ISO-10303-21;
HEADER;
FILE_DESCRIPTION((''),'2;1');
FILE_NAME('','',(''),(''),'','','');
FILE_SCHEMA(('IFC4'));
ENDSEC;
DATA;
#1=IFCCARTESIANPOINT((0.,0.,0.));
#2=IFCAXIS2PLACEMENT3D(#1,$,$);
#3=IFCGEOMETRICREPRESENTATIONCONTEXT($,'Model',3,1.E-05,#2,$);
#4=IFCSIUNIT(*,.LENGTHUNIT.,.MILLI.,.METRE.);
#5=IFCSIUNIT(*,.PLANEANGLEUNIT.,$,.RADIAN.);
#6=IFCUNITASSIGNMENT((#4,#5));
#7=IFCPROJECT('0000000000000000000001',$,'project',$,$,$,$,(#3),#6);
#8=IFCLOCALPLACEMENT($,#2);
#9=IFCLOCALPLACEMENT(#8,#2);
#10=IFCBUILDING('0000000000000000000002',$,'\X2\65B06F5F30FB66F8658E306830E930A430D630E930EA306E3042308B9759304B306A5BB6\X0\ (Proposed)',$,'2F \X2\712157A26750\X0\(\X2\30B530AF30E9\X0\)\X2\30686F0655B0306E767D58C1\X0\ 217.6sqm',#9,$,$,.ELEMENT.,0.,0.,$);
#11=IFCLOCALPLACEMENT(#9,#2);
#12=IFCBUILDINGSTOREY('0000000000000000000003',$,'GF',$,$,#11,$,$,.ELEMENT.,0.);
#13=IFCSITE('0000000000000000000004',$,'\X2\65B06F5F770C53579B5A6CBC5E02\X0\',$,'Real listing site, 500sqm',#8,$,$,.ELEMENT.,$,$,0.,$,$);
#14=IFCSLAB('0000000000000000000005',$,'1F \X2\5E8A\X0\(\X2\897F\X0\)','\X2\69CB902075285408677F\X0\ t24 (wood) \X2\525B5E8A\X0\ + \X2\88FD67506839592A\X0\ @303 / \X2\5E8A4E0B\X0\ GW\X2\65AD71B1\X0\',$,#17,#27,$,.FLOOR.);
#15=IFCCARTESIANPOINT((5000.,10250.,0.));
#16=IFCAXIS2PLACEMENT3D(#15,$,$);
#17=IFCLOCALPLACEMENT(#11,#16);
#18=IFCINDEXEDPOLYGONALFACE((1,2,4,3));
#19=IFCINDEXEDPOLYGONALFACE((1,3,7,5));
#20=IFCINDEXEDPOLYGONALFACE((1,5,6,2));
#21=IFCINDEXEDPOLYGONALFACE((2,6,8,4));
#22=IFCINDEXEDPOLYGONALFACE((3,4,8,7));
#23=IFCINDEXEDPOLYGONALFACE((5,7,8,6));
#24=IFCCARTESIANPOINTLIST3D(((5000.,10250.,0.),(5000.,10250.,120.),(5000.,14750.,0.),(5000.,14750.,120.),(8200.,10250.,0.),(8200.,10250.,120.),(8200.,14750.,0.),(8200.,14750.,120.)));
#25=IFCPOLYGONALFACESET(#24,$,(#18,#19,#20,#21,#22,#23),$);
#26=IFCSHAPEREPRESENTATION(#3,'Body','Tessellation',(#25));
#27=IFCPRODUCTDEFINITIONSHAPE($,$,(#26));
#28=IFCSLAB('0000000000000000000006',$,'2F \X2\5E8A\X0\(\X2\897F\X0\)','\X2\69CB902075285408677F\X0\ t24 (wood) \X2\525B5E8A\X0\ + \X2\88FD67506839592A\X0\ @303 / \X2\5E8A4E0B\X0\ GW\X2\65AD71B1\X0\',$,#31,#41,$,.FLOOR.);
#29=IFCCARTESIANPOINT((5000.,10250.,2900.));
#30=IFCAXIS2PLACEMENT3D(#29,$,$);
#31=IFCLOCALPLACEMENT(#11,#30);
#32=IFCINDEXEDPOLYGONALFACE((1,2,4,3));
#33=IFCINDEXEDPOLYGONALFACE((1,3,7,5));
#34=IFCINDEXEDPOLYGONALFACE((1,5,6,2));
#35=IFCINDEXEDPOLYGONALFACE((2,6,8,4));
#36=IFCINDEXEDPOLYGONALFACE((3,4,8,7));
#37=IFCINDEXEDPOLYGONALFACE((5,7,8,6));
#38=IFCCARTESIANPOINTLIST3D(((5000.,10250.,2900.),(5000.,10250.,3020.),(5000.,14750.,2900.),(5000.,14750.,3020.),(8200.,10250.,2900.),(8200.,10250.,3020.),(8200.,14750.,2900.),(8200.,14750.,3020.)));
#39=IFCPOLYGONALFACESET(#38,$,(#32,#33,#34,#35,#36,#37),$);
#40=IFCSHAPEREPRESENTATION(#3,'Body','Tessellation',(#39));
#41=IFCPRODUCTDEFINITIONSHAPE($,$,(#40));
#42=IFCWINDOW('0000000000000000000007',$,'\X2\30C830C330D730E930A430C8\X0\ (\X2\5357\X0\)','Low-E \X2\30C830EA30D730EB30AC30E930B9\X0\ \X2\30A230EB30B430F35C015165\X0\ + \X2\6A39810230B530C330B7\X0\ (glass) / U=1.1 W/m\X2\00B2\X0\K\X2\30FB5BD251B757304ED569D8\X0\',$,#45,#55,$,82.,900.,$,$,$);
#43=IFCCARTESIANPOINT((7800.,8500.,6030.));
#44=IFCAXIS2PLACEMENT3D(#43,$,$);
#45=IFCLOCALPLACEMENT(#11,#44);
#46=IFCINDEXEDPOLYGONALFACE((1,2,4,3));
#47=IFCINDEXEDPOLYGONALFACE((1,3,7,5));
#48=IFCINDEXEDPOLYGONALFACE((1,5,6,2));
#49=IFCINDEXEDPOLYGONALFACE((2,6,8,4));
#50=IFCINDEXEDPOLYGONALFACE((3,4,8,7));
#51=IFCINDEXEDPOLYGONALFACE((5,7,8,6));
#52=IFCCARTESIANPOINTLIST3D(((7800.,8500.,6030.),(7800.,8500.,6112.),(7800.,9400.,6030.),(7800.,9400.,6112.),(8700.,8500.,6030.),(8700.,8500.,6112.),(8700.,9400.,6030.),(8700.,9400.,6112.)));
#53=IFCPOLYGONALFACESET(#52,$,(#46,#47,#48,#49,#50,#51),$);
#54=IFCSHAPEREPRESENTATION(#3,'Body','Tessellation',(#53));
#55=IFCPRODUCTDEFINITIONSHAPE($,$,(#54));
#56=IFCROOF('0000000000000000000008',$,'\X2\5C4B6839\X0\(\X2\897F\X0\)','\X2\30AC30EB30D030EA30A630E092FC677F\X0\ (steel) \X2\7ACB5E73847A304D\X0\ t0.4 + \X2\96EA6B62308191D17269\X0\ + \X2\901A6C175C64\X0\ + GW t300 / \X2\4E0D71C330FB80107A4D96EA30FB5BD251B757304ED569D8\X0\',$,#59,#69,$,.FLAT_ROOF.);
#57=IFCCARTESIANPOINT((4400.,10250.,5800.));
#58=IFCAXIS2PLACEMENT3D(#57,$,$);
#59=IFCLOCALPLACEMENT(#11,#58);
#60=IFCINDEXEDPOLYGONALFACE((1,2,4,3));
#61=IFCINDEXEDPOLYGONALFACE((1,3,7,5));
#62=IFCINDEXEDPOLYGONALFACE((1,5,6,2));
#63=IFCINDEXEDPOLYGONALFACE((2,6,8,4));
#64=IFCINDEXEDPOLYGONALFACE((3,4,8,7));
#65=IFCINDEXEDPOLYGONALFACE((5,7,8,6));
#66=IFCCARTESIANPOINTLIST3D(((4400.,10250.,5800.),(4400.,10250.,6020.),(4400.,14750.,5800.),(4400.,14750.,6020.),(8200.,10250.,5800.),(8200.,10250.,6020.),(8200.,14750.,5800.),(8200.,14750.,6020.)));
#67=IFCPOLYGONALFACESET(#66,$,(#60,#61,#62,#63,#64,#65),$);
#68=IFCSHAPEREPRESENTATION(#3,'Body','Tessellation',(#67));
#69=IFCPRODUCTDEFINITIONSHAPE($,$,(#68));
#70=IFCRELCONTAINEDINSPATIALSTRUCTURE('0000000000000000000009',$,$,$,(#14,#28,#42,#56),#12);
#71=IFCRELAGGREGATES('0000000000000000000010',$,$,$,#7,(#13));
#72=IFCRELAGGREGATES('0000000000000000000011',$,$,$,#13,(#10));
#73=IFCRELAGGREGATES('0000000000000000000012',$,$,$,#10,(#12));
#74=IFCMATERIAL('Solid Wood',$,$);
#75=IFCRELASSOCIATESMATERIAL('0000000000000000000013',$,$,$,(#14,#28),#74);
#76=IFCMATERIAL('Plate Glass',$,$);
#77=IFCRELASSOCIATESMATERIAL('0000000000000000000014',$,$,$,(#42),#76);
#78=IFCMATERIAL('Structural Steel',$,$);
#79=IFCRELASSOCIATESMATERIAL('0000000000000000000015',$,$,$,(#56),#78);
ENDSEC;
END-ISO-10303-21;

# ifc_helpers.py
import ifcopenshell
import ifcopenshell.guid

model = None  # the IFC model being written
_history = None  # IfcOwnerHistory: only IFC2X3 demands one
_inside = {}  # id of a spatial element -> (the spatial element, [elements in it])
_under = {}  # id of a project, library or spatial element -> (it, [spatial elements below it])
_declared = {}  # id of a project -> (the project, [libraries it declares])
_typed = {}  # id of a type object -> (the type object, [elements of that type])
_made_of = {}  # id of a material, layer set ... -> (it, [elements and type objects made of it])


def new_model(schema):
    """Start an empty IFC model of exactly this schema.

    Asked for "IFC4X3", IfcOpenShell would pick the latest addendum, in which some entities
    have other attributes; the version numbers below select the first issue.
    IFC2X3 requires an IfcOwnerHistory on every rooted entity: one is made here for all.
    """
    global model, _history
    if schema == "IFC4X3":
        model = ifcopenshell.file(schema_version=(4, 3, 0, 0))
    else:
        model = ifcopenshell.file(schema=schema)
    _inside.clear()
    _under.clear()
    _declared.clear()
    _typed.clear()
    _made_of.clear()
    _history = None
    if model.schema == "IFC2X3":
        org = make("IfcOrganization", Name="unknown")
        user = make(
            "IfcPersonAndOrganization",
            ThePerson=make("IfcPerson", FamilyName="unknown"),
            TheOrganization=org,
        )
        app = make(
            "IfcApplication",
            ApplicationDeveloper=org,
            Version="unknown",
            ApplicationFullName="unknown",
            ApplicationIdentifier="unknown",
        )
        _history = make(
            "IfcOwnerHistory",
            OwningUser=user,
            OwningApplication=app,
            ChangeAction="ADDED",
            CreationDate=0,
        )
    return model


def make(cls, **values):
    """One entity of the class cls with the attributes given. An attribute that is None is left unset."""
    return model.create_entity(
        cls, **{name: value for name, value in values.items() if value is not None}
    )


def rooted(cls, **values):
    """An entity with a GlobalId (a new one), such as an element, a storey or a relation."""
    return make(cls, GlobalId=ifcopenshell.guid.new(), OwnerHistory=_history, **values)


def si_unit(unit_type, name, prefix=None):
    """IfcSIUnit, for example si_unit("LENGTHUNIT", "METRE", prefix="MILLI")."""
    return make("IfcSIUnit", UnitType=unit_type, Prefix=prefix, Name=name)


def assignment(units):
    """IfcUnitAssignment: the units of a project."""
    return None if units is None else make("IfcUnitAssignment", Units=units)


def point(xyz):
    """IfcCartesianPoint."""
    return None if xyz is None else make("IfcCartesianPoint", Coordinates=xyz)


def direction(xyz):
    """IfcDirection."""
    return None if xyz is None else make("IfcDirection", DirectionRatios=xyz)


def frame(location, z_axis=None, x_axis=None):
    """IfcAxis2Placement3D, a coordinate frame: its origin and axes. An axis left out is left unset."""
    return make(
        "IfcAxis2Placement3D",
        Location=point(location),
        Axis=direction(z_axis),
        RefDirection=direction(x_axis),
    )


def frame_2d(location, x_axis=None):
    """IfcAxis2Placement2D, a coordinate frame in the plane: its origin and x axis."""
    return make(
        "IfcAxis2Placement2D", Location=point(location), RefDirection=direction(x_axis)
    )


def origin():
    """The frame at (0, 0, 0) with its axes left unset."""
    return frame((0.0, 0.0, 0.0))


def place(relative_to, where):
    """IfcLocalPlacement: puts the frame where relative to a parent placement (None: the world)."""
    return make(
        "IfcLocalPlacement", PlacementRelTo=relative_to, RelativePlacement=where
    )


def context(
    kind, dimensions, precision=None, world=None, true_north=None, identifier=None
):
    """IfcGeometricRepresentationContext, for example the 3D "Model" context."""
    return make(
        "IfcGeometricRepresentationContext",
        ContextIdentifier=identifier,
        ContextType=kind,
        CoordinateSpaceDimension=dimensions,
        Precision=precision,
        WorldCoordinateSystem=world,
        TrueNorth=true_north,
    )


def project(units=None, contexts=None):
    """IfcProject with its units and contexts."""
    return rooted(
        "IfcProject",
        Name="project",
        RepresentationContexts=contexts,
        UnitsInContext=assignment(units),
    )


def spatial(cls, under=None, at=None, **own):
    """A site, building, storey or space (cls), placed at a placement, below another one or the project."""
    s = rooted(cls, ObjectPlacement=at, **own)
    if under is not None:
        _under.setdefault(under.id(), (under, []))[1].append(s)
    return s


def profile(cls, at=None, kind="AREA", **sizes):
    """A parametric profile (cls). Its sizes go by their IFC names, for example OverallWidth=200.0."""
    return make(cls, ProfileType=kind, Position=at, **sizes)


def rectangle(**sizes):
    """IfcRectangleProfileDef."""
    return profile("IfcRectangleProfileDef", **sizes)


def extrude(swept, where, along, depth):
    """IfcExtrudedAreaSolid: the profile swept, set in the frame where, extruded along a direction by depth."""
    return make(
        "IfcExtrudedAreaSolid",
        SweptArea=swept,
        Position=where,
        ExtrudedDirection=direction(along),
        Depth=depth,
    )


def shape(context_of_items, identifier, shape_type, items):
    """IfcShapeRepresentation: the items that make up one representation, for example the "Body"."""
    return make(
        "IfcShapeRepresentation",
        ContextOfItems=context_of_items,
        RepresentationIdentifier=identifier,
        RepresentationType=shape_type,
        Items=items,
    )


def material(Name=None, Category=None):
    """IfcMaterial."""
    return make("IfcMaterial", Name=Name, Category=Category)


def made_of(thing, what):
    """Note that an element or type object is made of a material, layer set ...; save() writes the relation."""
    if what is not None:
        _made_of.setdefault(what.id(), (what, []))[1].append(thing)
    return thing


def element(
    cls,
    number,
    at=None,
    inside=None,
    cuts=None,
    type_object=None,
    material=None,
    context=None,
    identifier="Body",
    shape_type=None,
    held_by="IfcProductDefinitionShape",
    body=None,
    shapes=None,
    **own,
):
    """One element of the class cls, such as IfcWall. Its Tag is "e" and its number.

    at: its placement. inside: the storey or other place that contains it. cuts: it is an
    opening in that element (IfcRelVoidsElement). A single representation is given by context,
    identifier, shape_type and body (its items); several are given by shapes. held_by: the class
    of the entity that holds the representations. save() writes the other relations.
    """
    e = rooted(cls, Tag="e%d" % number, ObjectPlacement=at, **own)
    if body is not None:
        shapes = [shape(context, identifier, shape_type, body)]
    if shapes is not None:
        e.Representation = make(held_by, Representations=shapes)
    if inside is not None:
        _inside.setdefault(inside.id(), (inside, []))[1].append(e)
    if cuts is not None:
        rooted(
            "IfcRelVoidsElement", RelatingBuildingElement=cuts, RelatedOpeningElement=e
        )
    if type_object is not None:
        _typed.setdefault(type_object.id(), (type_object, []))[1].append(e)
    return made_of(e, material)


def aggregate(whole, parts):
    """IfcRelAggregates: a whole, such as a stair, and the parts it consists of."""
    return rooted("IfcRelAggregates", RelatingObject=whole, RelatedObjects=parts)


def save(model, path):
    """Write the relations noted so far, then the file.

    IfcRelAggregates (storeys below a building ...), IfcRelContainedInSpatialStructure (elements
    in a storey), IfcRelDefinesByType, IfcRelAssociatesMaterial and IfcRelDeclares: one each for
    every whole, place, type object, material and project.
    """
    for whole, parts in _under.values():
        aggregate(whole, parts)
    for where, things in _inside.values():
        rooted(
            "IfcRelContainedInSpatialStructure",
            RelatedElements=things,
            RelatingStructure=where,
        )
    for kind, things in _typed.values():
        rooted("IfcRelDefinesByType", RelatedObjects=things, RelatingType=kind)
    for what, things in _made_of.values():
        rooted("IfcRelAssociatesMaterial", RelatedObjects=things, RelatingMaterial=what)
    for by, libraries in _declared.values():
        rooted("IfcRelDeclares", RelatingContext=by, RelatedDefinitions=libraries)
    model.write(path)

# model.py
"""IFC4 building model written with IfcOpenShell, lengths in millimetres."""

from ifc_helpers import new_model, si_unit, frame, frame_2d, origin, place, context, project, spatial, rectangle, extrude, material, element, save


model = new_model("IFC4")

# Units and contexts
model_context = context("Model", 3, precision=1e-05, world=origin())
ifc_project = project(units=[si_unit("LENGTHUNIT", "METRE", prefix="MILLI"), si_unit("PLANEANGLEUNIT", "RADIAN")], contexts=[model_context])

# Site, building, storey
site_placement = place(None, origin())
site = spatial("IfcSite", under=ifc_project, at=site_placement, Name="新潟県南魚沼市", ObjectType="Real listing site, 500sqm", CompositionType="ELEMENT", RefElevation=0.0)
building_placement = place(site_placement, origin())
building = spatial("IfcBuilding", under=site, at=building_placement, Name="新潟・書斎とライブラリのある静かな家 (Proposed)", ObjectType="2F 無垢材(サクラ)と漆喰の白壁 217.6sqm", CompositionType="ELEMENT", ElevationOfRefHeight=0.0, ElevationOfTerrain=0.0)
storey_placement = place(building_placement, origin())
storey = spatial("IfcBuildingStorey", under=building, at=storey_placement, Name="GF", CompositionType="ELEMENT", Elevation=0.0)

# Shared definitions
ifc_material_1 = material(Name="Solid Wood")

# Slabs
slab_1_placement = place(storey_placement, frame((5000.0, 10250.0, 0.0)))
element("IfcSlab", 1, at=slab_1_placement, inside=storey, material=ifc_material_1, Name="1F 床(西)", Description="構造用合板 t24 (wood) 剛床 + 製材根太 @303 / 床下 GW断熱", PredefinedType="FLOOR", context=model_context, shape_type="SweptSolid", body=[
    extrude(rectangle(XDim=3200.0, YDim=4500.0, at=frame_2d((1600.0, 2250.0))), frame((5000.0, 10250.0, 0.0)), (0.0, 0.0, 1.0), 120.0),
])
slab_2_placement = place(storey_placement, frame((5000.0, 10250.0, 2900.0)))
element("IfcSlab", 2, at=slab_2_placement, inside=storey, material=ifc_material_1, Name="2F 床(西)", Description="構造用合板 t24 (wood) 剛床 + 製材根太 @303 / 床下 GW断熱", PredefinedType="FLOOR", context=model_context, shape_type="SweptSolid", body=[
    extrude(rectangle(XDim=3200.0, YDim=4500.0, at=frame_2d((1600.0, 2250.0))), frame((5000.0, 10250.0, 2900.0)), (0.0, 0.0, 1.0), 120.0),
])

# Window
ifc_material_2 = material(Name="Plate Glass")
window_placement = place(storey_placement, frame((7800.0, 8500.0, 6030.0)))
element("IfcWindow", 3, at=window_placement, inside=storey, material=ifc_material_2, Name="トップライト (南)", Description="Low-E トリプルガラス アルゴン封入 + 樹脂サッシ (glass) / U=1.1 W/m²K・寒冷地仕様", OverallHeight=82.0, OverallWidth=900.0, context=model_context, shape_type="SweptSolid", body=[
    extrude(rectangle(XDim=900.0, YDim=900.0, at=frame_2d((450.0, 450.0))), frame((7800.0, 8500.0, 6030.0)), (0.0, 0.0, 1.0), 82.0),
])

# Roof
ifc_material_3 = material(Name="Structural Steel")
for number, where, name in (
    (4, (4400.0, 10250.0, 5800.0), "屋根(西)"),
):
    element("IfcRoof", number, at=place(storey_placement, frame(where)), inside=storey, material=ifc_material_3, Name=name, Description="ガルバリウム鋼板 (steel) 立平葺き t0.4 + 雪止め金物 + 通気層 + GW t300 / 不燃・耐積雪・寒冷地仕様", PredefinedType="FLAT_ROOF", context=model_context, shape_type="SweptSolid", body=[
        extrude(rectangle(XDim=3800.0, YDim=4500.0, at=frame_2d((1900.0, 2250.0))), frame((4400.0, 10250.0, 5800.0)), (0.0, 0.0, 1.0), 220.0),
    ])

save(model, "model.ifc")
